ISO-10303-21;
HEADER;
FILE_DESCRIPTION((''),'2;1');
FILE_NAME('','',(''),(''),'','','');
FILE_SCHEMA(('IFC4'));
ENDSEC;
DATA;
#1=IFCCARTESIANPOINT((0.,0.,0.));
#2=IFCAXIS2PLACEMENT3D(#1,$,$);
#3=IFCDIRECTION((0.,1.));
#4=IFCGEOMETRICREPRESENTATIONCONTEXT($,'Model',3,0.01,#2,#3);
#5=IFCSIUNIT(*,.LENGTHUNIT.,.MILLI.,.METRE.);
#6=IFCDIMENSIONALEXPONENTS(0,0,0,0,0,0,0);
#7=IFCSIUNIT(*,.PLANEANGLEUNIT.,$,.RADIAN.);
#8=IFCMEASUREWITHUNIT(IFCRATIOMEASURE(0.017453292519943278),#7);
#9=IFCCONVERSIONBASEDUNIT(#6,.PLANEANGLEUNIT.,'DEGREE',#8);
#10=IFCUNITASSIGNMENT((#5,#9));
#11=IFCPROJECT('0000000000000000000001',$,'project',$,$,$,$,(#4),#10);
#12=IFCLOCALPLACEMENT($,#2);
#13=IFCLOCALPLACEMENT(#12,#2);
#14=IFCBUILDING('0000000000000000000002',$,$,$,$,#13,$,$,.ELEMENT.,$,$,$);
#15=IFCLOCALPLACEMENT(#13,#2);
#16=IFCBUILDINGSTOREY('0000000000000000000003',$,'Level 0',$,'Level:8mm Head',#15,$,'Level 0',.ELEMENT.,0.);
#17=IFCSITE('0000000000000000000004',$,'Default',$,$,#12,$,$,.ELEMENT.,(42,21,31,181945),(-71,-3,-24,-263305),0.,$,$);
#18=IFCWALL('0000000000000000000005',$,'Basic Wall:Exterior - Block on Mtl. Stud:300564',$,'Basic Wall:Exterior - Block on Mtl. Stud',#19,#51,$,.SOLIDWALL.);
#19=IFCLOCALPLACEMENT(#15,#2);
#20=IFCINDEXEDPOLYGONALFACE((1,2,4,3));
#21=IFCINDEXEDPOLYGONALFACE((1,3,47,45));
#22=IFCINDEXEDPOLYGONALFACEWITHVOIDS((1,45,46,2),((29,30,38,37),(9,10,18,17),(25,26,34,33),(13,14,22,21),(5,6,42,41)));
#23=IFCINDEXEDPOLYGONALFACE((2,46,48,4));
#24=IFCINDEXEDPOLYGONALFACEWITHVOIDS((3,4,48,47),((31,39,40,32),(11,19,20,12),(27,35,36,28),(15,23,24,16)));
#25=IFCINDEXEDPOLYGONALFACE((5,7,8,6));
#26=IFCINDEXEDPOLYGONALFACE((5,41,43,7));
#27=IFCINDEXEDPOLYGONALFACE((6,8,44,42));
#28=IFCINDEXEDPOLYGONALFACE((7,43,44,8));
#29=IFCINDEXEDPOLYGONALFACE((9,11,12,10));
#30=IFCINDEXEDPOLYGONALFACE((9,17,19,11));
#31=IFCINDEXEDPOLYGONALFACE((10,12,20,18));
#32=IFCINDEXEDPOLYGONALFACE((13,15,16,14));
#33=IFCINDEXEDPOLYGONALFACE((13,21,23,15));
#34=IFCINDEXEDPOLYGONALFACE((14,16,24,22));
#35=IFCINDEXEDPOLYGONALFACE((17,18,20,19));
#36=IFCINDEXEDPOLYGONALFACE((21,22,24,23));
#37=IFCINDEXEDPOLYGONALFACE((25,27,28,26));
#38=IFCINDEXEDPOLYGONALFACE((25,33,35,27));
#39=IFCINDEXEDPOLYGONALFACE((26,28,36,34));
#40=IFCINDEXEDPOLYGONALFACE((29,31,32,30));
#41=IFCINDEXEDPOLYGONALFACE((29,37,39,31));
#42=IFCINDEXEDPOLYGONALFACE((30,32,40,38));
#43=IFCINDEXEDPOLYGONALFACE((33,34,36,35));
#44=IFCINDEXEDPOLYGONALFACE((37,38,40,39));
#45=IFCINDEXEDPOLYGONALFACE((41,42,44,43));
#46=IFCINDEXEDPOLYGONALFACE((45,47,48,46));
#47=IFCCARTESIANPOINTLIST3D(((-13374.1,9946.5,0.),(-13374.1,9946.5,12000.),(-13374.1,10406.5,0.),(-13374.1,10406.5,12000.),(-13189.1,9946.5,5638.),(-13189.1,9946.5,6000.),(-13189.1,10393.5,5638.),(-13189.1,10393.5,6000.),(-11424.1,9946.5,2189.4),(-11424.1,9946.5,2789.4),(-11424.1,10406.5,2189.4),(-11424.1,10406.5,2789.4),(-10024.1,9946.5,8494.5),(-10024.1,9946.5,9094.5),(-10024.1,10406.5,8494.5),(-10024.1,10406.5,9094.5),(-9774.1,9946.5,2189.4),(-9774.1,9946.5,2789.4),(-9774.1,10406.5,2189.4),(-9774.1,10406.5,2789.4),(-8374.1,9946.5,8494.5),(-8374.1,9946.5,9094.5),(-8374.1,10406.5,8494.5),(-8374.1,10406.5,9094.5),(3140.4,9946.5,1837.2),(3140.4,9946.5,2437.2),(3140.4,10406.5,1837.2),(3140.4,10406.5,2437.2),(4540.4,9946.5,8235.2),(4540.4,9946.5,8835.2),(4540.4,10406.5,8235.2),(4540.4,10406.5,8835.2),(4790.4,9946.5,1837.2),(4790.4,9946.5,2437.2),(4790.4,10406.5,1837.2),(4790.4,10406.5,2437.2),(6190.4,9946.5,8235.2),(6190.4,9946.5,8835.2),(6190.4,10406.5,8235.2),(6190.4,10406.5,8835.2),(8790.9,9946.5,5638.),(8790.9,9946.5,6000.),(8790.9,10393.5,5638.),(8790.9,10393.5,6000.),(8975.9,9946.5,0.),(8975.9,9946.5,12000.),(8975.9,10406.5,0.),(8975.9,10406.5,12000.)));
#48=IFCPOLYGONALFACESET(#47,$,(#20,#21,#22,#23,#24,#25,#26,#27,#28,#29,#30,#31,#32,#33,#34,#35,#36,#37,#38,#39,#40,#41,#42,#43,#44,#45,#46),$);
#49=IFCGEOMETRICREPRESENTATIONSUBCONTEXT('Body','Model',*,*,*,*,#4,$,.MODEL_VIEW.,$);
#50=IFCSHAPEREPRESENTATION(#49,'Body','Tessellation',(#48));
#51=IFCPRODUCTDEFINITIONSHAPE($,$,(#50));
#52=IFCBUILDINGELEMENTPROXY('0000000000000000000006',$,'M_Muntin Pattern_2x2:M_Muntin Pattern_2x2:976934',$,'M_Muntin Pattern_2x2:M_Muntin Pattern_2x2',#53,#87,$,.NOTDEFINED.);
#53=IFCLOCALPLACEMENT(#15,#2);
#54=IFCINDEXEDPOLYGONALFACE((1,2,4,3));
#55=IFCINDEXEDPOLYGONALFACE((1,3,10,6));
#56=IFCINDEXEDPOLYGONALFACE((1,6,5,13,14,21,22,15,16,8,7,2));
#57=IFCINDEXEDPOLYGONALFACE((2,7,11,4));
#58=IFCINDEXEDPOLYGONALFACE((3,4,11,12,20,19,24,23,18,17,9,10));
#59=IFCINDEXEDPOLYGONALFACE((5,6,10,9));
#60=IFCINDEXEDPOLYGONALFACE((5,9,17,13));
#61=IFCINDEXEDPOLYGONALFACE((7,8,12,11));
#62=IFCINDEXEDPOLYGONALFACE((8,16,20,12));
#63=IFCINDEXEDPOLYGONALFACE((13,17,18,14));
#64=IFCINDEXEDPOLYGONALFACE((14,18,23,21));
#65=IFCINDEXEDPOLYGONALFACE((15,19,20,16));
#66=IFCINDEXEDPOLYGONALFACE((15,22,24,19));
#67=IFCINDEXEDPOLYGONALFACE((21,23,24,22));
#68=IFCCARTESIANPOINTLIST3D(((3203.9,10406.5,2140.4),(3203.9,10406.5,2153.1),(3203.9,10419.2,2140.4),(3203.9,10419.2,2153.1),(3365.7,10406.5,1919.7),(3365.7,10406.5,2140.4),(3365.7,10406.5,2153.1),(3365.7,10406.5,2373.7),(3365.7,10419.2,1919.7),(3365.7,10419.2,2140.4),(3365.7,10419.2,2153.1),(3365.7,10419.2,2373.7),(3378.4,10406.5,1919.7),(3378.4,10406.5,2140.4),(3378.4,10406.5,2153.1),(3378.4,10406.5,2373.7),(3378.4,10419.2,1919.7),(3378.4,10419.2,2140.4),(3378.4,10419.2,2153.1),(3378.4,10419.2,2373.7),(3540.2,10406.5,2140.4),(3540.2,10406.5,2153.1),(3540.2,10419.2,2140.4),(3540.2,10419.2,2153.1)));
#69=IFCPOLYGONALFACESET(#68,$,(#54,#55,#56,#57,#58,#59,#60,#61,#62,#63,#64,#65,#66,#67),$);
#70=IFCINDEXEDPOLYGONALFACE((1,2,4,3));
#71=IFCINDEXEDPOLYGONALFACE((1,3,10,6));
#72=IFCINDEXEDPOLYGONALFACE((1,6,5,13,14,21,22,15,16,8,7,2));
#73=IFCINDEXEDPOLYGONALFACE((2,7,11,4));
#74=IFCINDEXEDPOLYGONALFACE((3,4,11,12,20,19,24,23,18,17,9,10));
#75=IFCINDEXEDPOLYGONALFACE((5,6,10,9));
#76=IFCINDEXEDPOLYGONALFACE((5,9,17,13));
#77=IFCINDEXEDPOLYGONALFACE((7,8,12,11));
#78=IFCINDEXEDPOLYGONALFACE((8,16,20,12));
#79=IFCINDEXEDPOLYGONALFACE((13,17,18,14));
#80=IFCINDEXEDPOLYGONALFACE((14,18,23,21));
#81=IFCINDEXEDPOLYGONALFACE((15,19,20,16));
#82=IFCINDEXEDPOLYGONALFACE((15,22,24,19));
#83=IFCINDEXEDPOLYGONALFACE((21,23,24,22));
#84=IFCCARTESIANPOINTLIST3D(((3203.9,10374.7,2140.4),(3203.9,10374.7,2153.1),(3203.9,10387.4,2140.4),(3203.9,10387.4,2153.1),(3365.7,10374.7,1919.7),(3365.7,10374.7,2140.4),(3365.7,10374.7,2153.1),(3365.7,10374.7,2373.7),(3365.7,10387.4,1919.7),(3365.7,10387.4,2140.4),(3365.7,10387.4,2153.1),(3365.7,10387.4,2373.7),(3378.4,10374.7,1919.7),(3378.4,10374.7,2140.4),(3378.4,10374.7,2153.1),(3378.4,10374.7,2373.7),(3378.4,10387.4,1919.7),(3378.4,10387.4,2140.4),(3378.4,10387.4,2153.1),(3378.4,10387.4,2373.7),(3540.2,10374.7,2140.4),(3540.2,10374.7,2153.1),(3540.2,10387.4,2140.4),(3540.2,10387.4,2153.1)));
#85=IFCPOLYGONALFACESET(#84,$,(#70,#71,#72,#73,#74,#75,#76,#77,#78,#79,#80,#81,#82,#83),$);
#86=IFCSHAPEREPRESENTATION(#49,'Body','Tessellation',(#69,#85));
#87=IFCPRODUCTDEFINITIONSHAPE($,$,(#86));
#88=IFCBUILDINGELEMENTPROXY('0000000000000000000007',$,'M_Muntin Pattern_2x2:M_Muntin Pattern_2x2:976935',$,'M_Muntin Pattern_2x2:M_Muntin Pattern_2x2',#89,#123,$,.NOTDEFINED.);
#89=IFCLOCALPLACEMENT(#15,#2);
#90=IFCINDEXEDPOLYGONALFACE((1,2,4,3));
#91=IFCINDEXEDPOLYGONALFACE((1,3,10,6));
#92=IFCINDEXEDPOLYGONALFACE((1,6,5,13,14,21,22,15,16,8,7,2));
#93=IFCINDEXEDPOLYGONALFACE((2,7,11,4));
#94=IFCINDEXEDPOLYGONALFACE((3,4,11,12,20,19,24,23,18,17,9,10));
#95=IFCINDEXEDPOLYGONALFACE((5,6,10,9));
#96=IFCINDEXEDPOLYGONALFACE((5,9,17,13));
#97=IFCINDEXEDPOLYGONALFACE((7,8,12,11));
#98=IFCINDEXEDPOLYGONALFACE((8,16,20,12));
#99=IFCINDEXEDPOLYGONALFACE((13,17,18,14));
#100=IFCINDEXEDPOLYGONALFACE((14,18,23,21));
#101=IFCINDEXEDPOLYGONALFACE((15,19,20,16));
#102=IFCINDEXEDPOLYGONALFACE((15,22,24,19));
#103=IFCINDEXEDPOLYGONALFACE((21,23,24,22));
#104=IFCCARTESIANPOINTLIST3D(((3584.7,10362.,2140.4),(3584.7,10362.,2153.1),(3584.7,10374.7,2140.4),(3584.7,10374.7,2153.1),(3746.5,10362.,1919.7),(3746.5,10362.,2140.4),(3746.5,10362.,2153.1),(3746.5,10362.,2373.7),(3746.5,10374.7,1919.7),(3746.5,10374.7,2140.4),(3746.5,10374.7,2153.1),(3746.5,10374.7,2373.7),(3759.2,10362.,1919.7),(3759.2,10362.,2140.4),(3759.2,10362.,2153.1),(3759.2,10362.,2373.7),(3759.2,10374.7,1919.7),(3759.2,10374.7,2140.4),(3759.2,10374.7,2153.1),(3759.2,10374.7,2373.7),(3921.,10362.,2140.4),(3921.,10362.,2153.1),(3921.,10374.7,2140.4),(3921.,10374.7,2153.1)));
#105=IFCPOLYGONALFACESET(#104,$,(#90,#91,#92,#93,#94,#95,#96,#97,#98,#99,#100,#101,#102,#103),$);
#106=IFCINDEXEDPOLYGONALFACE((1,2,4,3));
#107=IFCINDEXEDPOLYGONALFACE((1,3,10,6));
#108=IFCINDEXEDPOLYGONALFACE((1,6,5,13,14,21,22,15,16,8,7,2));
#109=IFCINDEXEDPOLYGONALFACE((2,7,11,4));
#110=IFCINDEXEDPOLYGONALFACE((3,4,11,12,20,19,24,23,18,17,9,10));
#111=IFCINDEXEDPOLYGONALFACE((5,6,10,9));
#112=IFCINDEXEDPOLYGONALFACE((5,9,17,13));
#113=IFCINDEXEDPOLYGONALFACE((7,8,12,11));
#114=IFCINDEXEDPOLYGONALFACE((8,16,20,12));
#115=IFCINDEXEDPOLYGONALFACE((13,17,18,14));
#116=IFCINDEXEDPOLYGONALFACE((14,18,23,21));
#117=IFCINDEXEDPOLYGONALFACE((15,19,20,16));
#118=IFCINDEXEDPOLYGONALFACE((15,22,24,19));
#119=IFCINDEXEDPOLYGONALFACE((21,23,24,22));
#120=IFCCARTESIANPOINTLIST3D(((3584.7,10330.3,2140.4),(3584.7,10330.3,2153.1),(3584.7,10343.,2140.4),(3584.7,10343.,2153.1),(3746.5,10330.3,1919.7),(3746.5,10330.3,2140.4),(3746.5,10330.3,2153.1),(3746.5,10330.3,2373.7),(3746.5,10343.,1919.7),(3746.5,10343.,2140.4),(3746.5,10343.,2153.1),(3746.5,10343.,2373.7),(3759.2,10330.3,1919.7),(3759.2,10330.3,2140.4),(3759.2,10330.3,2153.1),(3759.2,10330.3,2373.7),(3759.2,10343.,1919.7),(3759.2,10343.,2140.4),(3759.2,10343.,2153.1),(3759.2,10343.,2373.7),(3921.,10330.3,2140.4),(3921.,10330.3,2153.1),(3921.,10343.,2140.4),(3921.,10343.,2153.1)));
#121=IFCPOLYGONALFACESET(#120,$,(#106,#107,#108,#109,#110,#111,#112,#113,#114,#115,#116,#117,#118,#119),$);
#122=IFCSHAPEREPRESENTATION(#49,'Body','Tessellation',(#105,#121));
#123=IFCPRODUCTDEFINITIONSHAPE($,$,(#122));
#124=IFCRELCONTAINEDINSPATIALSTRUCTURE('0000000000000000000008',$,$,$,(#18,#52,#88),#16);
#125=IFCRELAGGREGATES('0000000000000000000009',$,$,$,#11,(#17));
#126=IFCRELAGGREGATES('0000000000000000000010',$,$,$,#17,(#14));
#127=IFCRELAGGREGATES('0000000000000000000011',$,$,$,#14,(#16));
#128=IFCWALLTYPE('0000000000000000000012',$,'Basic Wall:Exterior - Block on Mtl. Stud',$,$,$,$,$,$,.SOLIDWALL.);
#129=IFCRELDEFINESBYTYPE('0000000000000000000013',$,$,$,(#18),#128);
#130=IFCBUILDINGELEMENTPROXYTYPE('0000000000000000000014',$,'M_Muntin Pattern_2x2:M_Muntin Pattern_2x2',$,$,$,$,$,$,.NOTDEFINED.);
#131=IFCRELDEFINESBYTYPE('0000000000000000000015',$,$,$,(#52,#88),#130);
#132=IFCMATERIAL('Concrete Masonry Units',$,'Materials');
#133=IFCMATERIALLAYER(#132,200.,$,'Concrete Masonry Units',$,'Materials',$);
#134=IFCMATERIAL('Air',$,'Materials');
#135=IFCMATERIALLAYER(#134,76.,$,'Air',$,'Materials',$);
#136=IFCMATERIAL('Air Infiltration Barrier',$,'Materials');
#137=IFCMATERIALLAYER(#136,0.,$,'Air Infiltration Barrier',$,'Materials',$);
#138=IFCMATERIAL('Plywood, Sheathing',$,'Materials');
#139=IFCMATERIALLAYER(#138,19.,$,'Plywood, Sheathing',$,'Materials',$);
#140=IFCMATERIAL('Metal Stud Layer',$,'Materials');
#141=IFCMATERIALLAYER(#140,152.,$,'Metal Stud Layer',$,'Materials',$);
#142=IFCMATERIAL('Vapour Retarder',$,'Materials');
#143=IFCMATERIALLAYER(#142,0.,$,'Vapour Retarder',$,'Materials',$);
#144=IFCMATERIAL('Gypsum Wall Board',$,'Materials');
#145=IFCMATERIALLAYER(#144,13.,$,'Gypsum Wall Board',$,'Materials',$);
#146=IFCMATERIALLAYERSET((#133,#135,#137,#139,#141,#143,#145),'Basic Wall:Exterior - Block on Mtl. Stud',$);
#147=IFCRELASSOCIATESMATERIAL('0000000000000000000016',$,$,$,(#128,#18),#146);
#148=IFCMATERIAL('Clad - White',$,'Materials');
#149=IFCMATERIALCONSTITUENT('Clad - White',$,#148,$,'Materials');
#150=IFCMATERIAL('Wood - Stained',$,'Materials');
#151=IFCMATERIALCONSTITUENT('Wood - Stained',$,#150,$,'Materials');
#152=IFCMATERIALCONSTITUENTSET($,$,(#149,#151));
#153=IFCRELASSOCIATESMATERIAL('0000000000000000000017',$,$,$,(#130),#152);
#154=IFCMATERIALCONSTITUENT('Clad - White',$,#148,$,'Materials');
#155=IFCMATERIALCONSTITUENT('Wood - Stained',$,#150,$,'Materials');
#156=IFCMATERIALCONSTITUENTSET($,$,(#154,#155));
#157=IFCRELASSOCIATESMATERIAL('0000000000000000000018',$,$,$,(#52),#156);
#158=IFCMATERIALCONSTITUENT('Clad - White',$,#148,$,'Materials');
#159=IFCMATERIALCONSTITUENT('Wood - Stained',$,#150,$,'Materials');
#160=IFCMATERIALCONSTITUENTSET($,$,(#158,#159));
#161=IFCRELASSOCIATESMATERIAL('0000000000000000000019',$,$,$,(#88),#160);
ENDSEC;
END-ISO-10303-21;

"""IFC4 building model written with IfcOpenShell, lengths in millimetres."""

from ifc_helpers import new_model, entity, si_unit, converted_unit, direction, frame, frame_2d, origin, place, context, subcontext, project, spatial, polyline, rectangle, outline, extrude, source, transform, mapped, material, layer, layer_set, layer_usage, constituent, constituent_set, type_object, type_shapes, element, save


model = new_model("IFC4")

# Units and contexts
model_context = context("Model", 3, precision=0.01, world=origin(), true_north=direction((0.0, 1.0)))
body_context = subcontext(model_context, "Body", "Model", "MODEL_VIEW")
ifc_project = project(units=[si_unit("LENGTHUNIT", "METRE", prefix="MILLI"), converted_unit("PLANEANGLEUNIT", "DEGREE", entity("IfcRatioMeasure", 0.017453292519943278), si_unit("PLANEANGLEUNIT", "RADIAN"), dimensions=[0, 0, 0, 0, 0, 0, 0])], contexts=[model_context])

# Site, building, storey
site_placement = place(None, origin())
site = spatial("IfcSite", under=ifc_project, at=site_placement, Name="Default", CompositionType="ELEMENT", RefLatitude=(42, 21, 31, 181945), RefLongitude=(-71, -3, -24, -263305), RefElevation=0.0)
building_placement = place(site_placement, origin())
building = spatial("IfcBuilding", under=site, at=building_placement, CompositionType="ELEMENT")
storey_placement = place(building_placement, origin())
storey = spatial("IfcBuildingStorey", under=building, at=storey_placement, Name="Level 0", ObjectType="Level:8mm Head", LongName="Level 0", CompositionType="ELEMENT", Elevation=0.0)

# Wall, openings
ifc_material_1 = material(Name="Concrete Masonry Units", Category="Materials")
ifc_layer_1 = layer(ifc_material_1, 200.0, Name="Concrete Masonry Units", Category="Materials")
ifc_material_2 = material(Name="Air", Category="Materials")
ifc_layer_2 = layer(ifc_material_2, 76.0, Name="Air", Category="Materials")
ifc_material_3 = material(Name="Air Infiltration Barrier", Category="Materials")
ifc_layer_3 = layer(ifc_material_3, 0.0, Name="Air Infiltration Barrier", Category="Materials")
ifc_material_4 = material(Name="Plywood, Sheathing", Category="Materials")
ifc_layer_4 = layer(ifc_material_4, 19.0, Name="Plywood, Sheathing", Category="Materials")
ifc_material_5 = material(Name="Metal Stud Layer", Category="Materials")
ifc_layer_5 = layer(ifc_material_5, 152.0, Name="Metal Stud Layer", Category="Materials")
ifc_material_6 = material(Name="Vapour Retarder", Category="Materials")
ifc_layer_6 = layer(ifc_material_6, 0.0, Name="Vapour Retarder", Category="Materials")
ifc_material_7 = material(Name="Gypsum Wall Board", Category="Materials")
ifc_layer_7 = layer(ifc_material_7, 13.0, Name="Gypsum Wall Board", Category="Materials")
ifc_layer_set = layer_set([ifc_layer_1, ifc_layer_2, ifc_layer_3, ifc_layer_4, ifc_layer_5, ifc_layer_6, ifc_layer_7], Name="Basic Wall:Exterior - Block on Mtl. Stud")
ifc_layer_usage = layer_usage(ifc_layer_set, "AXIS2", "POSITIVE", -230.0)
wall_type = type_object("IfcWallType", Name="Basic Wall:Exterior - Block on Mtl. Stud", PredefinedType="SOLIDWALL", material=ifc_layer_set)
wall_placement = place(storey_placement, frame((-13374.1, 10176.5, 0.0)))
wall = element("IfcWall", 1, at=wall_placement, inside=storey, type_object=wall_type, material=ifc_layer_usage, Name="Basic Wall:Exterior - Block on Mtl. Stud:300564", ObjectType="Basic Wall:Exterior - Block on Mtl. Stud", PredefinedType="SOLIDWALL", context=body_context, shape_type="SweptSolid", body=[
    extrude(rectangle(XDim=22350.0, YDim=460.0, at=frame_2d((11175.0, 0.0), x_axis=(-1.0, 0.0))), origin(), (0.0, 0.0, 1.0), 12000.0),
])
opening_1_placement = place(storey_placement, frame((-13374.1, 10176.5, 0.0)))
element("IfcOpeningElement", 2, at=opening_1_placement, cuts=wall, PredefinedType="OPENING", context=body_context, shape_type="SweptSolid", body=[
    extrude(rectangle(XDim=21980.0, YDim=447.0, at=frame_2d((0.0, -74.5), x_axis=(1.0, 0.0))), frame((11175.0, -81.0, 5638.0), z_axis=(0.0, 0.0, 1.0), x_axis=(-1.0, 0.0, 0.0)), (0.0, 0.0, 1.0), 362.0),
])
opening_2_placement = place(wall_placement, frame((16514.5, -230.0, 1837.2)))
element("IfcOpeningElement", 3, at=opening_2_placement, cuts=wall, PredefinedType="OPENING", context=body_context, shape_type="SweptSolid", body=[
    extrude(rectangle(XDim=600.0, YDim=1650.0, at=frame_2d((300.0, 825.0), x_axis=(-1.0, 0.0))), frame((0.0, 0.0, 0.0), z_axis=(0.0, 1.0, 0.0), x_axis=(0.0, 0.0, 1.0)), (0.0, 0.0, 1.0), 460.0),
])
opening_3_placement = place(wall_placement, frame((1950.0, -230.0, 2189.4)))
element("IfcOpeningElement", 4, at=opening_3_placement, cuts=wall, PredefinedType="OPENING", context=body_context, shape_type="SweptSolid", body=[
    extrude(rectangle(XDim=600.0, YDim=1650.0, at=frame_2d((300.0, 825.0), x_axis=(-1.0, 0.0))), frame((0.0, 0.0, 0.0), z_axis=(0.0, 1.0, 0.0), x_axis=(0.0, 0.0, 1.0)), (0.0, 0.0, 1.0), 460.0),
])
opening_4_placement = place(wall_placement, frame((17914.5, -230.0, 8235.2)))
element("IfcOpeningElement", 5, at=opening_4_placement, cuts=wall, PredefinedType="OPENING", context=body_context, shape_type="SweptSolid", body=[
    extrude(rectangle(XDim=600.0, YDim=1650.0, at=frame_2d((300.0, 825.0), x_axis=(-1.0, 0.0))), frame((0.0, 0.0, 0.0), z_axis=(0.0, 1.0, 0.0), x_axis=(0.0, 0.0, 1.0)), (0.0, 0.0, 1.0), 460.0),
])
opening_5_placement = place(wall_placement, frame((3350.0, -230.0, 8494.5)))
element("IfcOpeningElement", 6, at=opening_5_placement, cuts=wall, PredefinedType="OPENING", context=body_context, shape_type="SweptSolid", body=[
    extrude(rectangle(XDim=600.0, YDim=1650.0, at=frame_2d((300.0, 825.0), x_axis=(-1.0, 0.0))), frame((0.0, 0.0, 0.0), z_axis=(0.0, 1.0, 0.0), x_axis=(0.0, 0.0, 1.0)), (0.0, 0.0, 1.0), 460.0),
])

# Building element proxies
ifc_material_8 = material(Name="Clad - White", Category="Materials")
ifc_constituent_1 = constituent(ifc_material_8, Name="Clad - White", Category="Materials")
ifc_material_9 = material(Name="Wood - Stained", Category="Materials")
ifc_constituent_2 = constituent(ifc_material_9, Name="Wood - Stained", Category="Materials")
ifc_constituent_set_1 = constituent_set(constituents=[ifc_constituent_1, ifc_constituent_2])
ifc_constituent_3 = constituent(ifc_material_8, Name="Clad - White", Category="Materials")
ifc_constituent_4 = constituent(ifc_material_9, Name="Wood - Stained", Category="Materials")
ifc_constituent_set_2 = constituent_set(constituents=[ifc_constituent_3, ifc_constituent_4])
building_element_proxy_type_1 = type_object("IfcBuildingElementProxyType", Name="M_Muntin Pattern_2x2:M_Muntin Pattern_2x2", PredefinedType="NOTDEFINED", material=ifc_constituent_set_2)
shared_shape_1 = source(origin(), body_context, "Body", "SweptSolid", [
    extrude(outline(polyline([(6.4, -6.4), (227.0, -6.4), (227.0, 6.3), (6.4, 6.3), (6.4, 168.2), (-6.3, 168.2), (-6.3, 6.3), (-227.0, 6.3), (-227.0, -6.4), (-6.3, -6.4), (-6.3, -168.1), (6.4, -168.1), (6.4, -6.4)])), frame((0.0, 9.5, 227.0), z_axis=(0.0, 1.0, 0.0), x_axis=(0.0, 0.0, 1.0)), (0.0, 0.0, 1.0), 12.7),
    extrude(outline(polyline([(6.4, -6.4), (227.0, -6.4), (227.0, 6.3), (6.4, 6.3), (6.4, 168.2), (-6.3, 168.2), (-6.3, 6.3), (-227.0, 6.3), (-227.0, -6.4), (-6.3, -6.4), (-6.3, -168.1), (6.4, -168.1), (6.4, -6.4)])), frame((0.0, -22.2, 227.0), z_axis=(0.0, 1.0, 0.0), x_axis=(0.0, 0.0, 1.0)), (0.0, 0.0, 1.0), 12.7),
])
type_shapes(building_element_proxy_type_1, [shared_shape_1])
proxy_1_placement = place(storey_placement, frame((3372.1, 10396.9, 1919.7)))
element("IfcBuildingElementProxy", 7, at=proxy_1_placement, inside=storey, type_object=building_element_proxy_type_1, material=ifc_constituent_set_1, Name="M_Muntin Pattern_2x2:M_Muntin Pattern_2x2:976934", ObjectType="M_Muntin Pattern_2x2:M_Muntin Pattern_2x2", PredefinedType="NOTDEFINED", context=body_context, shape_type="MappedRepresentation", body=[
    mapped(shared_shape_1, transform((0.0, 0.0, 0.0), scale=1.0)),
])
ifc_constituent_5 = constituent(ifc_material_8, Name="Clad - White", Category="Materials")
ifc_constituent_6 = constituent(ifc_material_9, Name="Wood - Stained", Category="Materials")
ifc_constituent_set_3 = constituent_set(constituents=[ifc_constituent_5, ifc_constituent_6])
proxy_2_placement = place(storey_placement, frame((3752.8, 10352.5, 1919.7)))
element("IfcBuildingElementProxy", 8, at=proxy_2_placement, inside=storey, type_object=building_element_proxy_type_1, material=ifc_constituent_set_3, Name="M_Muntin Pattern_2x2:M_Muntin Pattern_2x2:976935", ObjectType="M_Muntin Pattern_2x2:M_Muntin Pattern_2x2", PredefinedType="NOTDEFINED", context=body_context, shape_type="MappedRepresentation", body=[
    mapped(shared_shape_1, transform((0.0, 0.0, 0.0), scale=1.0)),
])

save(model, "model.ifc")
